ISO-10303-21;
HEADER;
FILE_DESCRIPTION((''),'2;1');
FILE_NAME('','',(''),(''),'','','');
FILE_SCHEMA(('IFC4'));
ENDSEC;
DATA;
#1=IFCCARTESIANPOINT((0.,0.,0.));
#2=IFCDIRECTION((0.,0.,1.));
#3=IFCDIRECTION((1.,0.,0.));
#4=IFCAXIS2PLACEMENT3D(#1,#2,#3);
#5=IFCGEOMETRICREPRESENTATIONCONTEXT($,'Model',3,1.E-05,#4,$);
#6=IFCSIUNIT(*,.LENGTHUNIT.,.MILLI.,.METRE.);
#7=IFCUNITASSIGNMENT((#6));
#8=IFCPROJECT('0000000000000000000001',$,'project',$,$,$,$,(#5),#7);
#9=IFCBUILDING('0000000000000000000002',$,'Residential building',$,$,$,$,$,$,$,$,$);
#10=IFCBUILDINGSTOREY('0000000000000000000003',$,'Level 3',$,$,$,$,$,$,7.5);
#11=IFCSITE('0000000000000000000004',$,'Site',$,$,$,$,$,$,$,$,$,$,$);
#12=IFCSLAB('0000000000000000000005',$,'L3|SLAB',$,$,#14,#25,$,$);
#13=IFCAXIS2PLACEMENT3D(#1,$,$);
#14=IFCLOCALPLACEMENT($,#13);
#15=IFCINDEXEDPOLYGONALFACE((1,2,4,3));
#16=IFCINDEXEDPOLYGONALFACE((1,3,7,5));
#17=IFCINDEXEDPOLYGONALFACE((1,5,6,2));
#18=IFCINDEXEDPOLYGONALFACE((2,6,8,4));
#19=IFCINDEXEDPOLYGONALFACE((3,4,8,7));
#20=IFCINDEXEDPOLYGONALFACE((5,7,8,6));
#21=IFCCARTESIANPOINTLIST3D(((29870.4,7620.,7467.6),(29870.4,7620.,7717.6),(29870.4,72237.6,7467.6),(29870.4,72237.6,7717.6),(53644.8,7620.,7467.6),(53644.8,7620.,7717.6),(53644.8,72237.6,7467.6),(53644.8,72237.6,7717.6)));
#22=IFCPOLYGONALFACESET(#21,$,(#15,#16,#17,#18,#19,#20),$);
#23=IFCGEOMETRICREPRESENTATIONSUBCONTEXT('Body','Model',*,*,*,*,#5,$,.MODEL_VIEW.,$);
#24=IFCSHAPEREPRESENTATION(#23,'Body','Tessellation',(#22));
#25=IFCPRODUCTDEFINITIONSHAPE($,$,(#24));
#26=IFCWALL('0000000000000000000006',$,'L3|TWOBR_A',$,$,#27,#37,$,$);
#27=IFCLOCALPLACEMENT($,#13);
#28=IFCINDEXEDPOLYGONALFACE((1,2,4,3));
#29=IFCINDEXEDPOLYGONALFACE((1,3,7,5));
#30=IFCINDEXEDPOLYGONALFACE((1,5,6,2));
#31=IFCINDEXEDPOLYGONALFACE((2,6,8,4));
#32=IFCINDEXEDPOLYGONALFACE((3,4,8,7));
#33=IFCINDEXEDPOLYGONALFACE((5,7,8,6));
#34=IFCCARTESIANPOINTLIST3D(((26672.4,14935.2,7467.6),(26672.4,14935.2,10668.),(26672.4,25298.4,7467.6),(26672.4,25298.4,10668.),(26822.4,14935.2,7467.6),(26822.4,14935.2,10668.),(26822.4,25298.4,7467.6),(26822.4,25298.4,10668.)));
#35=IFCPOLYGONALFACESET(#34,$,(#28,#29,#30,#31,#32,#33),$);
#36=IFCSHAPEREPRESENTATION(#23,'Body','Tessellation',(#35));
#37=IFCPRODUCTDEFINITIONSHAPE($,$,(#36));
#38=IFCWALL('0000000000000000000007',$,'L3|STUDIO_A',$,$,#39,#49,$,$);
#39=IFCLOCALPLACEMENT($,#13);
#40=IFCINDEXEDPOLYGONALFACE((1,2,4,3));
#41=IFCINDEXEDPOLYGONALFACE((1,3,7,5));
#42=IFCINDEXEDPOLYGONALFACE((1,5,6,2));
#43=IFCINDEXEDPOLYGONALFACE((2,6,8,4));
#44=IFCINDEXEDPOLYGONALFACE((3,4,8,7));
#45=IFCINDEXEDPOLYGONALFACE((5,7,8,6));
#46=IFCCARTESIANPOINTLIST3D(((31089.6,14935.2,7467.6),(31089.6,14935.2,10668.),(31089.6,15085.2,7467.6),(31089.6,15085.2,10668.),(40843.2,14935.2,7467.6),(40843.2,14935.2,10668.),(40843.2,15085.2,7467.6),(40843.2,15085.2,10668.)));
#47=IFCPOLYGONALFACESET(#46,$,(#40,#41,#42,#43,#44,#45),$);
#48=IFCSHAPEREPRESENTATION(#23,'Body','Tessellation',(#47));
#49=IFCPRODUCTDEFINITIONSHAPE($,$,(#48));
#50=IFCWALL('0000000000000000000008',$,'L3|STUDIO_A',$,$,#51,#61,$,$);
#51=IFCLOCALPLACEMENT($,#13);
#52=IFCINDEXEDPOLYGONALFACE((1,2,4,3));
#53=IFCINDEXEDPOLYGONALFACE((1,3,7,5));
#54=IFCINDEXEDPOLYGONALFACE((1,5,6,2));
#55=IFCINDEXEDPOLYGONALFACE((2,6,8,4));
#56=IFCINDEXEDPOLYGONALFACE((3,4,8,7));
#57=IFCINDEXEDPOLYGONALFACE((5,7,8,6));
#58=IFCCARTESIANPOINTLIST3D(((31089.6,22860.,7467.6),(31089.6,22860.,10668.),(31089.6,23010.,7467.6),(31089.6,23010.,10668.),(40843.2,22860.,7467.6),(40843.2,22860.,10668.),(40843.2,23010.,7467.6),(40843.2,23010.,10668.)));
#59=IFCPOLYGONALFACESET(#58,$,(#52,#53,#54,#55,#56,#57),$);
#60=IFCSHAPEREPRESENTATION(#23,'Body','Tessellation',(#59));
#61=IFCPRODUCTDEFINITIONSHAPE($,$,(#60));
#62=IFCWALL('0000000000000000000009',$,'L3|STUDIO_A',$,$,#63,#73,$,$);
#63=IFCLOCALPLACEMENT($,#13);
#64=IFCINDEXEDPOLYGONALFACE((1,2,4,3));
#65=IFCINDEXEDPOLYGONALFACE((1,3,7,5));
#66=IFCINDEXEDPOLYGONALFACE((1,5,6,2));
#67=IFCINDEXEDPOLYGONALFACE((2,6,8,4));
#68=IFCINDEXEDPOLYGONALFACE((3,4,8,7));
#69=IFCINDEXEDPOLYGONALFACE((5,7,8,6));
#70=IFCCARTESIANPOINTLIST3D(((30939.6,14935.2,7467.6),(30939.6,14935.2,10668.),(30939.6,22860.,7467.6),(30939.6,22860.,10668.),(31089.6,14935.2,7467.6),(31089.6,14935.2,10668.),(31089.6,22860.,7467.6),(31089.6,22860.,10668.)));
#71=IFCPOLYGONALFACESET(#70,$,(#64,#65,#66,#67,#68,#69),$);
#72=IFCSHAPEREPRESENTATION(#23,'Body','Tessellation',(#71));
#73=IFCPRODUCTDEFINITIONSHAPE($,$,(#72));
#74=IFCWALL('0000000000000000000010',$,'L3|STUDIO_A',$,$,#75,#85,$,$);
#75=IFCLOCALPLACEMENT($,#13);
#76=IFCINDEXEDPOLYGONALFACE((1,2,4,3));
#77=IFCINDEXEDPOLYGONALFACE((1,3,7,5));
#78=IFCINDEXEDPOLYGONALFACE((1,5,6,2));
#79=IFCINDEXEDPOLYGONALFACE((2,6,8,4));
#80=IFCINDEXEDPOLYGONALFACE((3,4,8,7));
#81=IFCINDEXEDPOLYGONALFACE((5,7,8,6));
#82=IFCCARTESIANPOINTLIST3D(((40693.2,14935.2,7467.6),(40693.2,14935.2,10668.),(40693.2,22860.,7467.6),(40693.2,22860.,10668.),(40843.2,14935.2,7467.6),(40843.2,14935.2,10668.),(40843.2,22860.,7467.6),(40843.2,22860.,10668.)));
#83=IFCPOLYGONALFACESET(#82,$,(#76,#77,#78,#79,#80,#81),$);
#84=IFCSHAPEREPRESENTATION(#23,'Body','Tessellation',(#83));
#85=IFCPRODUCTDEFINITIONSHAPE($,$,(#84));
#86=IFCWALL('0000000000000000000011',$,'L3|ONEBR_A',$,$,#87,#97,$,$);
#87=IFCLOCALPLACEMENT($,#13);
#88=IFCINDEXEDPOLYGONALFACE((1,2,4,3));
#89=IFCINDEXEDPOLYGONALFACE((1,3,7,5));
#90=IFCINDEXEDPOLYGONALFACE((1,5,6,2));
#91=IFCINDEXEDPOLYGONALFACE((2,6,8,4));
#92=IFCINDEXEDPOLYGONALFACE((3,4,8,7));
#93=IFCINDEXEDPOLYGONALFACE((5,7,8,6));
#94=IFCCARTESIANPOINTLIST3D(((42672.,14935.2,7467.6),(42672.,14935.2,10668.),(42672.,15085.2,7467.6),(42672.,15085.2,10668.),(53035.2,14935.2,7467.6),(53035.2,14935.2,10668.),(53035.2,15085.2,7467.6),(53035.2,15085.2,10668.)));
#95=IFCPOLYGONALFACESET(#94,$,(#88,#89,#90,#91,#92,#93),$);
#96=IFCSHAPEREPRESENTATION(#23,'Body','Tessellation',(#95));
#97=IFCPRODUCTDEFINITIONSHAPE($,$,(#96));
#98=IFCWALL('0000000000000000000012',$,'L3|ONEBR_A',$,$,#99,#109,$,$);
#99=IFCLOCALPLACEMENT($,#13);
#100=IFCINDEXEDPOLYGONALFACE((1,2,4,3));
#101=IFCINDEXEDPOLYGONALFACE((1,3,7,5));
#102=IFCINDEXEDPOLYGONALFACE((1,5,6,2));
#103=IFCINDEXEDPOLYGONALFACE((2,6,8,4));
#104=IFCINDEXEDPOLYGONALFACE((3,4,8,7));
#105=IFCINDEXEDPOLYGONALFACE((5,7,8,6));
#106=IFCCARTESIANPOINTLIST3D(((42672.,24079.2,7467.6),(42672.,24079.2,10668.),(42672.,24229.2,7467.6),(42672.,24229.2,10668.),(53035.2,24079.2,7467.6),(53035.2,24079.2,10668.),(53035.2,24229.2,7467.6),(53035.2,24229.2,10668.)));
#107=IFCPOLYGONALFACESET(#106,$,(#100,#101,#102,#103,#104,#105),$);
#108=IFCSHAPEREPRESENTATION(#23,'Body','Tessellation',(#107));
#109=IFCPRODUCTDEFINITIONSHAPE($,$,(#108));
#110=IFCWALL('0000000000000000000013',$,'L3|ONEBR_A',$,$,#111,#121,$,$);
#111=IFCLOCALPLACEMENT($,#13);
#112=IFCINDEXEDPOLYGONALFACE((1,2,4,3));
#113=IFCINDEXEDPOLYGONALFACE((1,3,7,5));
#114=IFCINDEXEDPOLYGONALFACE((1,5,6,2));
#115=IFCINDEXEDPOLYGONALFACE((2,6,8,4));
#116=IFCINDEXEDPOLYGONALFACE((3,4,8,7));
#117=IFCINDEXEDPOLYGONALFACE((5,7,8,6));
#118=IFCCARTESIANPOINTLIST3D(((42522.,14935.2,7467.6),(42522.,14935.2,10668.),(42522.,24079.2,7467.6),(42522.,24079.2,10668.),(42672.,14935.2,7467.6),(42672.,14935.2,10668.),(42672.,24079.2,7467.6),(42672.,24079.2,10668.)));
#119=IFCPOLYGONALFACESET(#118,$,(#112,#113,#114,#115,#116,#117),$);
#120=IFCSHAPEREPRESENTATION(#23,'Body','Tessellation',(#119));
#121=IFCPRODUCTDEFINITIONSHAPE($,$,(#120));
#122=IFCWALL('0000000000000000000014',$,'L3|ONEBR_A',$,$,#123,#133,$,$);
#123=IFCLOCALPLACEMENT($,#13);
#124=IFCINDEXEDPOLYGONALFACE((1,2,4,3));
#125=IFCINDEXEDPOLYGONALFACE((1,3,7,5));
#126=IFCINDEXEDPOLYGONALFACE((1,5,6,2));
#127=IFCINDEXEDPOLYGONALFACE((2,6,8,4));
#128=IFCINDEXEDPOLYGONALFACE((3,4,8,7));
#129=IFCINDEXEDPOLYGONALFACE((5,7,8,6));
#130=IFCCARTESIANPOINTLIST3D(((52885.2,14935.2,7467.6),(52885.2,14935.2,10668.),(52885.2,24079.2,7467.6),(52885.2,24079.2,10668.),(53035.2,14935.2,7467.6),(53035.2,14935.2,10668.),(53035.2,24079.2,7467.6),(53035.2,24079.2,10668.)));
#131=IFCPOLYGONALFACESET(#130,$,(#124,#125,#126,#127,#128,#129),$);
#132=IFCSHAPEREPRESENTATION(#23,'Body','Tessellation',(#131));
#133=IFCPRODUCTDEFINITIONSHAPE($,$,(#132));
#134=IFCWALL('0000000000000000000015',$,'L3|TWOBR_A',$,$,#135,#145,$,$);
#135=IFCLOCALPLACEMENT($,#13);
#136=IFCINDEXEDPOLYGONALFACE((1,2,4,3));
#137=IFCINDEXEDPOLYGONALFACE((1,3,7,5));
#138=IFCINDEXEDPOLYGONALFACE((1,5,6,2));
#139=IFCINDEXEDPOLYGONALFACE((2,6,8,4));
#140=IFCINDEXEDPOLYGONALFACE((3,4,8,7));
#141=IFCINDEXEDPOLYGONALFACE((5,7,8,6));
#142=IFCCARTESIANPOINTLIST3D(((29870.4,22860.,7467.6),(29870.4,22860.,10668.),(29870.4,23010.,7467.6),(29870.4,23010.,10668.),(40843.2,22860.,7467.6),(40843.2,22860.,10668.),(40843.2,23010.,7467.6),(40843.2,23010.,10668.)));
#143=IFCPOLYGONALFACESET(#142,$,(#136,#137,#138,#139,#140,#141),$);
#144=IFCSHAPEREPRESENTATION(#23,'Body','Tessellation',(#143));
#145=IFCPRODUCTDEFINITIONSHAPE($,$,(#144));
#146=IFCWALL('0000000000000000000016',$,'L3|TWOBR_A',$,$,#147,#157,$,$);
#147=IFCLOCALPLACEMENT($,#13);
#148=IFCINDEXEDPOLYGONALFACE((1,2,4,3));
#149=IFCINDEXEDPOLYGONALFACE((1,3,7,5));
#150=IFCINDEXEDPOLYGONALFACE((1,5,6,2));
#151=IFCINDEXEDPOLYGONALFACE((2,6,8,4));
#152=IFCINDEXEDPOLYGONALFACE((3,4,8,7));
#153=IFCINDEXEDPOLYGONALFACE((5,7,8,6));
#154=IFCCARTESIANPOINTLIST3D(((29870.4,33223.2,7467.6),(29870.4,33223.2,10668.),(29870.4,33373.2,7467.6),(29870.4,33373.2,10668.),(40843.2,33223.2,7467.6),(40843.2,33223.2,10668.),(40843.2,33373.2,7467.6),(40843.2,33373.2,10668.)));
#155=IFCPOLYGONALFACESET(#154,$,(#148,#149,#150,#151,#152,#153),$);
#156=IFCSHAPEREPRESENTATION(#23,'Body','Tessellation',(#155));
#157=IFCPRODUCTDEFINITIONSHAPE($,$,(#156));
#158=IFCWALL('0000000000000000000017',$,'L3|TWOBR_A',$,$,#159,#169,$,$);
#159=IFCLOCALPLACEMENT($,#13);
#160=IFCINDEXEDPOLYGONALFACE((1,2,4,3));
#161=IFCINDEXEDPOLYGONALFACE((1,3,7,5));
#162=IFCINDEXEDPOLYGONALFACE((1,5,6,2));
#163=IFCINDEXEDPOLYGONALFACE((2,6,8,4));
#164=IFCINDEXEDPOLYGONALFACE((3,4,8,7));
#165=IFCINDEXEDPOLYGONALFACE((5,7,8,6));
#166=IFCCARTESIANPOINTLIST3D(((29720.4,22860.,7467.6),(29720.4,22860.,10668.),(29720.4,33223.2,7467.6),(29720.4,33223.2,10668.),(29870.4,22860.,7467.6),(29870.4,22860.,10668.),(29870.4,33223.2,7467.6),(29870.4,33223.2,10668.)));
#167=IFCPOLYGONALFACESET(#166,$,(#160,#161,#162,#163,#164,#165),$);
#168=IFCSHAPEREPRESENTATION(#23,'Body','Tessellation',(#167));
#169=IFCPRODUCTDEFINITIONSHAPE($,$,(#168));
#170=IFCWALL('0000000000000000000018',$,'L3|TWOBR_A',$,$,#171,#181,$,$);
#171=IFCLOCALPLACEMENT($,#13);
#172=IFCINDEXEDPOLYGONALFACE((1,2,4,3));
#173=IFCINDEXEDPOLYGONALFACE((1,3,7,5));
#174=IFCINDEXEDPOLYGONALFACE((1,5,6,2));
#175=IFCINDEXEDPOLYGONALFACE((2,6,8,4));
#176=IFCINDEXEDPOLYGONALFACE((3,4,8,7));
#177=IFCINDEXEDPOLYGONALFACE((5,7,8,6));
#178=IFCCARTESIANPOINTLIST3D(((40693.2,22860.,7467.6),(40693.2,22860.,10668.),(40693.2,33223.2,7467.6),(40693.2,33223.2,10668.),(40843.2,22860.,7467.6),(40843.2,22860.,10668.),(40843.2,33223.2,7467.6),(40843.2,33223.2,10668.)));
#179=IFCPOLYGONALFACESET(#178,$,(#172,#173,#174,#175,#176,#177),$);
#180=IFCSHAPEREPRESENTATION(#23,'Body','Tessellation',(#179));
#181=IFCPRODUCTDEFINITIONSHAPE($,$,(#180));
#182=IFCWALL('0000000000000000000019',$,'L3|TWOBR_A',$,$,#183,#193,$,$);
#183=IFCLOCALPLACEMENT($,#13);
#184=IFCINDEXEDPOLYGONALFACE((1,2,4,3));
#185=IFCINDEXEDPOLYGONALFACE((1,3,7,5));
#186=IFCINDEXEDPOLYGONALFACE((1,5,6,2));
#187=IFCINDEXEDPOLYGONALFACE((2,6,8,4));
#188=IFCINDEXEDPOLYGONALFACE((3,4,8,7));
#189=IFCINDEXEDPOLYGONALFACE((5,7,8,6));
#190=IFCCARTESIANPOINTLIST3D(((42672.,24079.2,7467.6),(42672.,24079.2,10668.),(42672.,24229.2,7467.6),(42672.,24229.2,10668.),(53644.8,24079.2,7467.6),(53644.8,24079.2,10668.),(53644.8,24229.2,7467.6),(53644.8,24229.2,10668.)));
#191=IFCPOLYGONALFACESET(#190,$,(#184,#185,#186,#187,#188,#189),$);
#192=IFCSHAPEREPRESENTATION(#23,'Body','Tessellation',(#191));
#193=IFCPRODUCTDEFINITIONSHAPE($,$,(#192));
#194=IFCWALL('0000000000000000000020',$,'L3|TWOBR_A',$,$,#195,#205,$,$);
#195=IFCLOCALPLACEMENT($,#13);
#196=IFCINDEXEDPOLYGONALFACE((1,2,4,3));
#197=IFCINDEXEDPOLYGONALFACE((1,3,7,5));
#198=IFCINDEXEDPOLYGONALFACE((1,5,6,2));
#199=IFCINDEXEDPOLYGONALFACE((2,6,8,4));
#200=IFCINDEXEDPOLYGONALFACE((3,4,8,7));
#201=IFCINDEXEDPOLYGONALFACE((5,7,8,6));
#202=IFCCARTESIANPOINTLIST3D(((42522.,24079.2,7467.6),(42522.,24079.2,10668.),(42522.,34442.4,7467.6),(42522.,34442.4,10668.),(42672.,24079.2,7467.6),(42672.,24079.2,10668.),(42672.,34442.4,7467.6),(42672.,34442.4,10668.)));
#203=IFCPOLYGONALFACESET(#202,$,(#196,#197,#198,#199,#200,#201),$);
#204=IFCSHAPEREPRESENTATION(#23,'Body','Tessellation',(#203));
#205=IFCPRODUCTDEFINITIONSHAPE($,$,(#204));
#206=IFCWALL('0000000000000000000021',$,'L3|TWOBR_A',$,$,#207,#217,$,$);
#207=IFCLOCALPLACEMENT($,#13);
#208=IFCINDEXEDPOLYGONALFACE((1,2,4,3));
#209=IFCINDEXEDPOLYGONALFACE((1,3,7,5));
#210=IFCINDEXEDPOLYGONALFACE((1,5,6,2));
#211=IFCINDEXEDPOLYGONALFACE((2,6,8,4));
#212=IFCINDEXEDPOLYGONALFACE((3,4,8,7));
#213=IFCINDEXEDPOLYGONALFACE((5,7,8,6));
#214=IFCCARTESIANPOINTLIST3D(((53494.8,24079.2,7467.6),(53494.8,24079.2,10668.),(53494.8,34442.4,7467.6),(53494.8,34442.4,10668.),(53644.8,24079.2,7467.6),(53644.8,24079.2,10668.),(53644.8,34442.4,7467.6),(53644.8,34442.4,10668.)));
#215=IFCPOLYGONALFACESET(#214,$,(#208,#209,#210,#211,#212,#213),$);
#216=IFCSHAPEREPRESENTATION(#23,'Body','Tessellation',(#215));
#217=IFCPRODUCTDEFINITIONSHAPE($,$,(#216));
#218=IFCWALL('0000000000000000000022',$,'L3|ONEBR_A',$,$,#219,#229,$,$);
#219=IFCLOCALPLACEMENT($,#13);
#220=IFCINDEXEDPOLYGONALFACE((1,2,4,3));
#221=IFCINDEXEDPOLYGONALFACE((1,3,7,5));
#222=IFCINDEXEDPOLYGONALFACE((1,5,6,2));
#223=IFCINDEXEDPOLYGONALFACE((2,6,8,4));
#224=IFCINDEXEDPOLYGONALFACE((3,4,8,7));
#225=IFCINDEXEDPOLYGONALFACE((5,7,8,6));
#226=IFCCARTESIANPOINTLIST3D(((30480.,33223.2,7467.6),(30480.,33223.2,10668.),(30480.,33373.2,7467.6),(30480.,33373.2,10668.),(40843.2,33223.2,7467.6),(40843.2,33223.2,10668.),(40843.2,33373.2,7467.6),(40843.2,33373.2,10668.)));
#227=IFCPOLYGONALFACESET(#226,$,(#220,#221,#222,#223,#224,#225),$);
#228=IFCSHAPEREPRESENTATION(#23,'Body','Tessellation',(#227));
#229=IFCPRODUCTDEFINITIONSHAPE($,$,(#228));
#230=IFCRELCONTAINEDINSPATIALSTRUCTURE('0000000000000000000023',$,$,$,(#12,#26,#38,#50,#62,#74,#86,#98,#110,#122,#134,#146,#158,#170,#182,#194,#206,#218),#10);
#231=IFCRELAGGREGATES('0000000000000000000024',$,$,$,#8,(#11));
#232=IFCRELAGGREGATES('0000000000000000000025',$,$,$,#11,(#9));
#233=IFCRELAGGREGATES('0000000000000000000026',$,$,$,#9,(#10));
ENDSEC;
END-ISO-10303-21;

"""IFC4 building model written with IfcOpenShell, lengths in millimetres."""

from ifc_helpers import new_model, si_unit, frame, origin_with_axes, place, context, subcontext, project, spatial, indexed_curve, outline, extrude, element, save


model = new_model("IFC4")

# Units and contexts
model_context = context("Model", 3, precision=1e-05, world=origin_with_axes())
body_context = subcontext(model_context, "Body", "Model", "MODEL_VIEW")
ifc_project = project(units=[si_unit("LENGTHUNIT", "METRE", prefix="MILLI")], contexts=[model_context])

# Site, building, storey
site = spatial("IfcSite", under=ifc_project, Name="Site")
building = spatial("IfcBuilding", under=site, Name="Residential building")
storey = spatial("IfcBuildingStorey", under=building, Name="Level 3", Elevation=7.5)

# Slab
slab_placement = place(None, frame((29870.4, 7620.0, 7467.6), z_axis=(0.0, 0.0, 1.0), x_axis=(1.0, 0.0, 0.0)))
element("IfcSlab", 1, at=slab_placement, inside=storey, Name="L3|SLAB", context=body_context, shape_type="SweptSolid", body=[
    extrude(outline(indexed_curve([(0.0, 0.0), (23774.4, 0.0), (23774.4, 64617.6), (0.0, 64617.6), (0.0, 0.0)])), None, (0.0, 0.0, 1.0), 250.0),
])

# Walls
wall_1_placement = place(None, frame((26822.4, 14935.2, 7467.6), z_axis=(0.0, 0.0, 1.0), x_axis=(0.0, 1.0, 0.0)))
element("IfcWall", 2, at=wall_1_placement, inside=storey, Name="L3|TWOBR_A", context=body_context, shape_type="SweptSolid", body=[
    extrude(outline(indexed_curve([(0.0, 0.0), (0.0, 150.0), (10363.2, 150.0), (10363.2, 0.0), (0.0, 0.0)], self_intersect=False)), origin_with_axes(), (0.0, 0.0, 1.0), 3200.4),
])
for number, where, z_axis, x_axis, name in (
    (3, (31089.6, 14935.2, 7467.6), (0.0, 0.0, 1.0), (1.0, 0.0, 0.0), "L3|STUDIO_A"),
    (4, (31089.6, 22860.0, 7467.6), (0.0, 0.0, 1.0), (1.0, 0.0, 0.0), "L3|STUDIO_A"),
):
    element("IfcWall", number, at=place(None, frame(where, z_axis=z_axis, x_axis=x_axis)), inside=storey, Name=name, context=body_context, shape_type="SweptSolid", body=[
        extrude(outline(indexed_curve([(0.0, 0.0), (0.0, 150.0), (9753.6, 150.0), (9753.6, 0.0), (0.0, 0.0)], self_intersect=False)), origin_with_axes(), (0.0, 0.0, 1.0), 3200.4),
    ])
for number, where, z_axis, x_axis, name in (
    (5, (31089.6, 14935.2, 7467.6), (0.0, 0.0, 1.0), (0.0, 1.0, 0.0), "L3|STUDIO_A"),
    (6, (40843.2, 14935.2, 7467.6), (0.0, 0.0, 1.0), (0.0, 1.0, 0.0), "L3|STUDIO_A"),
):
    element("IfcWall", number, at=place(None, frame(where, z_axis=z_axis, x_axis=x_axis)), inside=storey, Name=name, context=body_context, shape_type="SweptSolid", body=[
        extrude(outline(indexed_curve([(0.0, 0.0), (0.0, 150.0), (7924.8, 150.0), (7924.8, 0.0), (0.0, 0.0)], self_intersect=False)), origin_with_axes(), (0.0, 0.0, 1.0), 3200.4),
    ])
for number, where, z_axis, x_axis, name in (
    (7, (42672.0, 14935.2, 7467.6), (0.0, 0.0, 1.0), (1.0, 0.0, 0.0), "L3|ONEBR_A"),
    (8, (42672.0, 24079.2, 7467.6), (0.0, 0.0, 1.0), (1.0, 0.0, 0.0), "L3|ONEBR_A"),
):
    element("IfcWall", number, at=place(None, frame(where, z_axis=z_axis, x_axis=x_axis)), inside=storey, Name=name, context=body_context, shape_type="SweptSolid", body=[
        extrude(outline(indexed_curve([(0.0, 0.0), (0.0, 150.0), (10363.2, 150.0), (10363.2, 0.0), (0.0, 0.0)], self_intersect=False)), origin_with_axes(), (0.0, 0.0, 1.0), 3200.4),
    ])
for number, where, z_axis, x_axis, name in (
    (9, (42672.0, 14935.2, 7467.6), (0.0, 0.0, 1.0), (0.0, 1.0, 0.0), "L3|ONEBR_A"),
    (10, (53035.2, 14935.2, 7467.6), (0.0, 0.0, 1.0), (0.0, 1.0, 0.0), "L3|ONEBR_A"),
):
    element("IfcWall", number, at=place(None, frame(where, z_axis=z_axis, x_axis=x_axis)), inside=storey, Name=name, context=body_context, shape_type="SweptSolid", body=[
        extrude(outline(indexed_curve([(0.0, 0.0), (0.0, 150.0), (9144.0, 150.0), (9144.0, 0.0), (0.0, 0.0)], self_intersect=False)), origin_with_axes(), (0.0, 0.0, 1.0), 3200.4),
    ])
for number, where, z_axis, x_axis, name in (
    (11, (29870.4, 22860.0, 7467.6), (0.0, 0.0, 1.0), (1.0, 0.0, 0.0), "L3|TWOBR_A"),
    (12, (29870.4, 33223.2, 7467.6), (0.0, 0.0, 1.0), (1.0, 0.0, 0.0), "L3|TWOBR_A"),
):
    element("IfcWall", number, at=place(None, frame(where, z_axis=z_axis, x_axis=x_axis)), inside=storey, Name=name, context=body_context, shape_type="SweptSolid", body=[
        extrude(outline(indexed_curve([(0.0, 0.0), (0.0, 150.0), (10972.8, 150.0), (10972.8, 0.0), (0.0, 0.0)], self_intersect=False)), origin_with_axes(), (0.0, 0.0, 1.0), 3200.4),
    ])
for number, where, z_axis, x_axis, name in (
    (13, (29870.4, 22860.0, 7467.6), (0.0, 0.0, 1.0), (0.0, 1.0, 0.0), "L3|TWOBR_A"),
    (14, (40843.2, 22860.0, 7467.6), (0.0, 0.0, 1.0), (0.0, 1.0, 0.0), "L3|TWOBR_A"),
):
    element("IfcWall", number, at=place(None, frame(where, z_axis=z_axis, x_axis=x_axis)), inside=storey, Name=name, context=body_context, shape_type="SweptSolid", body=[
        extrude(outline(indexed_curve([(0.0, 0.0), (0.0, 150.0), (10363.2, 150.0), (10363.2, 0.0), (0.0, 0.0)], self_intersect=False)), origin_with_axes(), (0.0, 0.0, 1.0), 3200.4),
    ])
wall_2_placement = place(None, frame((42672.0, 24079.2, 7467.6), z_axis=(0.0, 0.0, 1.0), x_axis=(1.0, 0.0, 0.0)))
element("IfcWall", 15, at=wall_2_placement, inside=storey, Name="L3|TWOBR_A", context=body_context, shape_type="SweptSolid", body=[
    extrude(outline(indexed_curve([(0.0, 0.0), (0.0, 150.0), (10972.8, 150.0), (10972.8, 0.0), (0.0, 0.0)], self_intersect=False)), origin_with_axes(), (0.0, 0.0, 1.0), 3200.4),
])
for number, where, z_axis, x_axis, name in (
    (16, (42672.0, 24079.2, 7467.6), (0.0, 0.0, 1.0), (0.0, 1.0, 0.0), "L3|TWOBR_A"),
    (17, (53644.8, 24079.2, 7467.6), (0.0, 0.0, 1.0), (0.0, 1.0, 0.0), "L3|TWOBR_A"),
    (18, (30480.0, 33223.2, 7467.6), (0.0, 0.0, 1.0), (1.0, 0.0, 0.0), "L3|ONEBR_A"),
):
    element("IfcWall", number, at=place(None, frame(where, z_axis=z_axis, x_axis=x_axis)), inside=storey, Name=name, context=body_context, shape_type="SweptSolid", body=[
        extrude(outline(indexed_curve([(0.0, 0.0), (0.0, 150.0), (10363.2, 150.0), (10363.2, 0.0), (0.0, 0.0)], self_intersect=False)), origin_with_axes(), (0.0, 0.0, 1.0), 3200.4),
    ])

save(model, "model.ifc")
